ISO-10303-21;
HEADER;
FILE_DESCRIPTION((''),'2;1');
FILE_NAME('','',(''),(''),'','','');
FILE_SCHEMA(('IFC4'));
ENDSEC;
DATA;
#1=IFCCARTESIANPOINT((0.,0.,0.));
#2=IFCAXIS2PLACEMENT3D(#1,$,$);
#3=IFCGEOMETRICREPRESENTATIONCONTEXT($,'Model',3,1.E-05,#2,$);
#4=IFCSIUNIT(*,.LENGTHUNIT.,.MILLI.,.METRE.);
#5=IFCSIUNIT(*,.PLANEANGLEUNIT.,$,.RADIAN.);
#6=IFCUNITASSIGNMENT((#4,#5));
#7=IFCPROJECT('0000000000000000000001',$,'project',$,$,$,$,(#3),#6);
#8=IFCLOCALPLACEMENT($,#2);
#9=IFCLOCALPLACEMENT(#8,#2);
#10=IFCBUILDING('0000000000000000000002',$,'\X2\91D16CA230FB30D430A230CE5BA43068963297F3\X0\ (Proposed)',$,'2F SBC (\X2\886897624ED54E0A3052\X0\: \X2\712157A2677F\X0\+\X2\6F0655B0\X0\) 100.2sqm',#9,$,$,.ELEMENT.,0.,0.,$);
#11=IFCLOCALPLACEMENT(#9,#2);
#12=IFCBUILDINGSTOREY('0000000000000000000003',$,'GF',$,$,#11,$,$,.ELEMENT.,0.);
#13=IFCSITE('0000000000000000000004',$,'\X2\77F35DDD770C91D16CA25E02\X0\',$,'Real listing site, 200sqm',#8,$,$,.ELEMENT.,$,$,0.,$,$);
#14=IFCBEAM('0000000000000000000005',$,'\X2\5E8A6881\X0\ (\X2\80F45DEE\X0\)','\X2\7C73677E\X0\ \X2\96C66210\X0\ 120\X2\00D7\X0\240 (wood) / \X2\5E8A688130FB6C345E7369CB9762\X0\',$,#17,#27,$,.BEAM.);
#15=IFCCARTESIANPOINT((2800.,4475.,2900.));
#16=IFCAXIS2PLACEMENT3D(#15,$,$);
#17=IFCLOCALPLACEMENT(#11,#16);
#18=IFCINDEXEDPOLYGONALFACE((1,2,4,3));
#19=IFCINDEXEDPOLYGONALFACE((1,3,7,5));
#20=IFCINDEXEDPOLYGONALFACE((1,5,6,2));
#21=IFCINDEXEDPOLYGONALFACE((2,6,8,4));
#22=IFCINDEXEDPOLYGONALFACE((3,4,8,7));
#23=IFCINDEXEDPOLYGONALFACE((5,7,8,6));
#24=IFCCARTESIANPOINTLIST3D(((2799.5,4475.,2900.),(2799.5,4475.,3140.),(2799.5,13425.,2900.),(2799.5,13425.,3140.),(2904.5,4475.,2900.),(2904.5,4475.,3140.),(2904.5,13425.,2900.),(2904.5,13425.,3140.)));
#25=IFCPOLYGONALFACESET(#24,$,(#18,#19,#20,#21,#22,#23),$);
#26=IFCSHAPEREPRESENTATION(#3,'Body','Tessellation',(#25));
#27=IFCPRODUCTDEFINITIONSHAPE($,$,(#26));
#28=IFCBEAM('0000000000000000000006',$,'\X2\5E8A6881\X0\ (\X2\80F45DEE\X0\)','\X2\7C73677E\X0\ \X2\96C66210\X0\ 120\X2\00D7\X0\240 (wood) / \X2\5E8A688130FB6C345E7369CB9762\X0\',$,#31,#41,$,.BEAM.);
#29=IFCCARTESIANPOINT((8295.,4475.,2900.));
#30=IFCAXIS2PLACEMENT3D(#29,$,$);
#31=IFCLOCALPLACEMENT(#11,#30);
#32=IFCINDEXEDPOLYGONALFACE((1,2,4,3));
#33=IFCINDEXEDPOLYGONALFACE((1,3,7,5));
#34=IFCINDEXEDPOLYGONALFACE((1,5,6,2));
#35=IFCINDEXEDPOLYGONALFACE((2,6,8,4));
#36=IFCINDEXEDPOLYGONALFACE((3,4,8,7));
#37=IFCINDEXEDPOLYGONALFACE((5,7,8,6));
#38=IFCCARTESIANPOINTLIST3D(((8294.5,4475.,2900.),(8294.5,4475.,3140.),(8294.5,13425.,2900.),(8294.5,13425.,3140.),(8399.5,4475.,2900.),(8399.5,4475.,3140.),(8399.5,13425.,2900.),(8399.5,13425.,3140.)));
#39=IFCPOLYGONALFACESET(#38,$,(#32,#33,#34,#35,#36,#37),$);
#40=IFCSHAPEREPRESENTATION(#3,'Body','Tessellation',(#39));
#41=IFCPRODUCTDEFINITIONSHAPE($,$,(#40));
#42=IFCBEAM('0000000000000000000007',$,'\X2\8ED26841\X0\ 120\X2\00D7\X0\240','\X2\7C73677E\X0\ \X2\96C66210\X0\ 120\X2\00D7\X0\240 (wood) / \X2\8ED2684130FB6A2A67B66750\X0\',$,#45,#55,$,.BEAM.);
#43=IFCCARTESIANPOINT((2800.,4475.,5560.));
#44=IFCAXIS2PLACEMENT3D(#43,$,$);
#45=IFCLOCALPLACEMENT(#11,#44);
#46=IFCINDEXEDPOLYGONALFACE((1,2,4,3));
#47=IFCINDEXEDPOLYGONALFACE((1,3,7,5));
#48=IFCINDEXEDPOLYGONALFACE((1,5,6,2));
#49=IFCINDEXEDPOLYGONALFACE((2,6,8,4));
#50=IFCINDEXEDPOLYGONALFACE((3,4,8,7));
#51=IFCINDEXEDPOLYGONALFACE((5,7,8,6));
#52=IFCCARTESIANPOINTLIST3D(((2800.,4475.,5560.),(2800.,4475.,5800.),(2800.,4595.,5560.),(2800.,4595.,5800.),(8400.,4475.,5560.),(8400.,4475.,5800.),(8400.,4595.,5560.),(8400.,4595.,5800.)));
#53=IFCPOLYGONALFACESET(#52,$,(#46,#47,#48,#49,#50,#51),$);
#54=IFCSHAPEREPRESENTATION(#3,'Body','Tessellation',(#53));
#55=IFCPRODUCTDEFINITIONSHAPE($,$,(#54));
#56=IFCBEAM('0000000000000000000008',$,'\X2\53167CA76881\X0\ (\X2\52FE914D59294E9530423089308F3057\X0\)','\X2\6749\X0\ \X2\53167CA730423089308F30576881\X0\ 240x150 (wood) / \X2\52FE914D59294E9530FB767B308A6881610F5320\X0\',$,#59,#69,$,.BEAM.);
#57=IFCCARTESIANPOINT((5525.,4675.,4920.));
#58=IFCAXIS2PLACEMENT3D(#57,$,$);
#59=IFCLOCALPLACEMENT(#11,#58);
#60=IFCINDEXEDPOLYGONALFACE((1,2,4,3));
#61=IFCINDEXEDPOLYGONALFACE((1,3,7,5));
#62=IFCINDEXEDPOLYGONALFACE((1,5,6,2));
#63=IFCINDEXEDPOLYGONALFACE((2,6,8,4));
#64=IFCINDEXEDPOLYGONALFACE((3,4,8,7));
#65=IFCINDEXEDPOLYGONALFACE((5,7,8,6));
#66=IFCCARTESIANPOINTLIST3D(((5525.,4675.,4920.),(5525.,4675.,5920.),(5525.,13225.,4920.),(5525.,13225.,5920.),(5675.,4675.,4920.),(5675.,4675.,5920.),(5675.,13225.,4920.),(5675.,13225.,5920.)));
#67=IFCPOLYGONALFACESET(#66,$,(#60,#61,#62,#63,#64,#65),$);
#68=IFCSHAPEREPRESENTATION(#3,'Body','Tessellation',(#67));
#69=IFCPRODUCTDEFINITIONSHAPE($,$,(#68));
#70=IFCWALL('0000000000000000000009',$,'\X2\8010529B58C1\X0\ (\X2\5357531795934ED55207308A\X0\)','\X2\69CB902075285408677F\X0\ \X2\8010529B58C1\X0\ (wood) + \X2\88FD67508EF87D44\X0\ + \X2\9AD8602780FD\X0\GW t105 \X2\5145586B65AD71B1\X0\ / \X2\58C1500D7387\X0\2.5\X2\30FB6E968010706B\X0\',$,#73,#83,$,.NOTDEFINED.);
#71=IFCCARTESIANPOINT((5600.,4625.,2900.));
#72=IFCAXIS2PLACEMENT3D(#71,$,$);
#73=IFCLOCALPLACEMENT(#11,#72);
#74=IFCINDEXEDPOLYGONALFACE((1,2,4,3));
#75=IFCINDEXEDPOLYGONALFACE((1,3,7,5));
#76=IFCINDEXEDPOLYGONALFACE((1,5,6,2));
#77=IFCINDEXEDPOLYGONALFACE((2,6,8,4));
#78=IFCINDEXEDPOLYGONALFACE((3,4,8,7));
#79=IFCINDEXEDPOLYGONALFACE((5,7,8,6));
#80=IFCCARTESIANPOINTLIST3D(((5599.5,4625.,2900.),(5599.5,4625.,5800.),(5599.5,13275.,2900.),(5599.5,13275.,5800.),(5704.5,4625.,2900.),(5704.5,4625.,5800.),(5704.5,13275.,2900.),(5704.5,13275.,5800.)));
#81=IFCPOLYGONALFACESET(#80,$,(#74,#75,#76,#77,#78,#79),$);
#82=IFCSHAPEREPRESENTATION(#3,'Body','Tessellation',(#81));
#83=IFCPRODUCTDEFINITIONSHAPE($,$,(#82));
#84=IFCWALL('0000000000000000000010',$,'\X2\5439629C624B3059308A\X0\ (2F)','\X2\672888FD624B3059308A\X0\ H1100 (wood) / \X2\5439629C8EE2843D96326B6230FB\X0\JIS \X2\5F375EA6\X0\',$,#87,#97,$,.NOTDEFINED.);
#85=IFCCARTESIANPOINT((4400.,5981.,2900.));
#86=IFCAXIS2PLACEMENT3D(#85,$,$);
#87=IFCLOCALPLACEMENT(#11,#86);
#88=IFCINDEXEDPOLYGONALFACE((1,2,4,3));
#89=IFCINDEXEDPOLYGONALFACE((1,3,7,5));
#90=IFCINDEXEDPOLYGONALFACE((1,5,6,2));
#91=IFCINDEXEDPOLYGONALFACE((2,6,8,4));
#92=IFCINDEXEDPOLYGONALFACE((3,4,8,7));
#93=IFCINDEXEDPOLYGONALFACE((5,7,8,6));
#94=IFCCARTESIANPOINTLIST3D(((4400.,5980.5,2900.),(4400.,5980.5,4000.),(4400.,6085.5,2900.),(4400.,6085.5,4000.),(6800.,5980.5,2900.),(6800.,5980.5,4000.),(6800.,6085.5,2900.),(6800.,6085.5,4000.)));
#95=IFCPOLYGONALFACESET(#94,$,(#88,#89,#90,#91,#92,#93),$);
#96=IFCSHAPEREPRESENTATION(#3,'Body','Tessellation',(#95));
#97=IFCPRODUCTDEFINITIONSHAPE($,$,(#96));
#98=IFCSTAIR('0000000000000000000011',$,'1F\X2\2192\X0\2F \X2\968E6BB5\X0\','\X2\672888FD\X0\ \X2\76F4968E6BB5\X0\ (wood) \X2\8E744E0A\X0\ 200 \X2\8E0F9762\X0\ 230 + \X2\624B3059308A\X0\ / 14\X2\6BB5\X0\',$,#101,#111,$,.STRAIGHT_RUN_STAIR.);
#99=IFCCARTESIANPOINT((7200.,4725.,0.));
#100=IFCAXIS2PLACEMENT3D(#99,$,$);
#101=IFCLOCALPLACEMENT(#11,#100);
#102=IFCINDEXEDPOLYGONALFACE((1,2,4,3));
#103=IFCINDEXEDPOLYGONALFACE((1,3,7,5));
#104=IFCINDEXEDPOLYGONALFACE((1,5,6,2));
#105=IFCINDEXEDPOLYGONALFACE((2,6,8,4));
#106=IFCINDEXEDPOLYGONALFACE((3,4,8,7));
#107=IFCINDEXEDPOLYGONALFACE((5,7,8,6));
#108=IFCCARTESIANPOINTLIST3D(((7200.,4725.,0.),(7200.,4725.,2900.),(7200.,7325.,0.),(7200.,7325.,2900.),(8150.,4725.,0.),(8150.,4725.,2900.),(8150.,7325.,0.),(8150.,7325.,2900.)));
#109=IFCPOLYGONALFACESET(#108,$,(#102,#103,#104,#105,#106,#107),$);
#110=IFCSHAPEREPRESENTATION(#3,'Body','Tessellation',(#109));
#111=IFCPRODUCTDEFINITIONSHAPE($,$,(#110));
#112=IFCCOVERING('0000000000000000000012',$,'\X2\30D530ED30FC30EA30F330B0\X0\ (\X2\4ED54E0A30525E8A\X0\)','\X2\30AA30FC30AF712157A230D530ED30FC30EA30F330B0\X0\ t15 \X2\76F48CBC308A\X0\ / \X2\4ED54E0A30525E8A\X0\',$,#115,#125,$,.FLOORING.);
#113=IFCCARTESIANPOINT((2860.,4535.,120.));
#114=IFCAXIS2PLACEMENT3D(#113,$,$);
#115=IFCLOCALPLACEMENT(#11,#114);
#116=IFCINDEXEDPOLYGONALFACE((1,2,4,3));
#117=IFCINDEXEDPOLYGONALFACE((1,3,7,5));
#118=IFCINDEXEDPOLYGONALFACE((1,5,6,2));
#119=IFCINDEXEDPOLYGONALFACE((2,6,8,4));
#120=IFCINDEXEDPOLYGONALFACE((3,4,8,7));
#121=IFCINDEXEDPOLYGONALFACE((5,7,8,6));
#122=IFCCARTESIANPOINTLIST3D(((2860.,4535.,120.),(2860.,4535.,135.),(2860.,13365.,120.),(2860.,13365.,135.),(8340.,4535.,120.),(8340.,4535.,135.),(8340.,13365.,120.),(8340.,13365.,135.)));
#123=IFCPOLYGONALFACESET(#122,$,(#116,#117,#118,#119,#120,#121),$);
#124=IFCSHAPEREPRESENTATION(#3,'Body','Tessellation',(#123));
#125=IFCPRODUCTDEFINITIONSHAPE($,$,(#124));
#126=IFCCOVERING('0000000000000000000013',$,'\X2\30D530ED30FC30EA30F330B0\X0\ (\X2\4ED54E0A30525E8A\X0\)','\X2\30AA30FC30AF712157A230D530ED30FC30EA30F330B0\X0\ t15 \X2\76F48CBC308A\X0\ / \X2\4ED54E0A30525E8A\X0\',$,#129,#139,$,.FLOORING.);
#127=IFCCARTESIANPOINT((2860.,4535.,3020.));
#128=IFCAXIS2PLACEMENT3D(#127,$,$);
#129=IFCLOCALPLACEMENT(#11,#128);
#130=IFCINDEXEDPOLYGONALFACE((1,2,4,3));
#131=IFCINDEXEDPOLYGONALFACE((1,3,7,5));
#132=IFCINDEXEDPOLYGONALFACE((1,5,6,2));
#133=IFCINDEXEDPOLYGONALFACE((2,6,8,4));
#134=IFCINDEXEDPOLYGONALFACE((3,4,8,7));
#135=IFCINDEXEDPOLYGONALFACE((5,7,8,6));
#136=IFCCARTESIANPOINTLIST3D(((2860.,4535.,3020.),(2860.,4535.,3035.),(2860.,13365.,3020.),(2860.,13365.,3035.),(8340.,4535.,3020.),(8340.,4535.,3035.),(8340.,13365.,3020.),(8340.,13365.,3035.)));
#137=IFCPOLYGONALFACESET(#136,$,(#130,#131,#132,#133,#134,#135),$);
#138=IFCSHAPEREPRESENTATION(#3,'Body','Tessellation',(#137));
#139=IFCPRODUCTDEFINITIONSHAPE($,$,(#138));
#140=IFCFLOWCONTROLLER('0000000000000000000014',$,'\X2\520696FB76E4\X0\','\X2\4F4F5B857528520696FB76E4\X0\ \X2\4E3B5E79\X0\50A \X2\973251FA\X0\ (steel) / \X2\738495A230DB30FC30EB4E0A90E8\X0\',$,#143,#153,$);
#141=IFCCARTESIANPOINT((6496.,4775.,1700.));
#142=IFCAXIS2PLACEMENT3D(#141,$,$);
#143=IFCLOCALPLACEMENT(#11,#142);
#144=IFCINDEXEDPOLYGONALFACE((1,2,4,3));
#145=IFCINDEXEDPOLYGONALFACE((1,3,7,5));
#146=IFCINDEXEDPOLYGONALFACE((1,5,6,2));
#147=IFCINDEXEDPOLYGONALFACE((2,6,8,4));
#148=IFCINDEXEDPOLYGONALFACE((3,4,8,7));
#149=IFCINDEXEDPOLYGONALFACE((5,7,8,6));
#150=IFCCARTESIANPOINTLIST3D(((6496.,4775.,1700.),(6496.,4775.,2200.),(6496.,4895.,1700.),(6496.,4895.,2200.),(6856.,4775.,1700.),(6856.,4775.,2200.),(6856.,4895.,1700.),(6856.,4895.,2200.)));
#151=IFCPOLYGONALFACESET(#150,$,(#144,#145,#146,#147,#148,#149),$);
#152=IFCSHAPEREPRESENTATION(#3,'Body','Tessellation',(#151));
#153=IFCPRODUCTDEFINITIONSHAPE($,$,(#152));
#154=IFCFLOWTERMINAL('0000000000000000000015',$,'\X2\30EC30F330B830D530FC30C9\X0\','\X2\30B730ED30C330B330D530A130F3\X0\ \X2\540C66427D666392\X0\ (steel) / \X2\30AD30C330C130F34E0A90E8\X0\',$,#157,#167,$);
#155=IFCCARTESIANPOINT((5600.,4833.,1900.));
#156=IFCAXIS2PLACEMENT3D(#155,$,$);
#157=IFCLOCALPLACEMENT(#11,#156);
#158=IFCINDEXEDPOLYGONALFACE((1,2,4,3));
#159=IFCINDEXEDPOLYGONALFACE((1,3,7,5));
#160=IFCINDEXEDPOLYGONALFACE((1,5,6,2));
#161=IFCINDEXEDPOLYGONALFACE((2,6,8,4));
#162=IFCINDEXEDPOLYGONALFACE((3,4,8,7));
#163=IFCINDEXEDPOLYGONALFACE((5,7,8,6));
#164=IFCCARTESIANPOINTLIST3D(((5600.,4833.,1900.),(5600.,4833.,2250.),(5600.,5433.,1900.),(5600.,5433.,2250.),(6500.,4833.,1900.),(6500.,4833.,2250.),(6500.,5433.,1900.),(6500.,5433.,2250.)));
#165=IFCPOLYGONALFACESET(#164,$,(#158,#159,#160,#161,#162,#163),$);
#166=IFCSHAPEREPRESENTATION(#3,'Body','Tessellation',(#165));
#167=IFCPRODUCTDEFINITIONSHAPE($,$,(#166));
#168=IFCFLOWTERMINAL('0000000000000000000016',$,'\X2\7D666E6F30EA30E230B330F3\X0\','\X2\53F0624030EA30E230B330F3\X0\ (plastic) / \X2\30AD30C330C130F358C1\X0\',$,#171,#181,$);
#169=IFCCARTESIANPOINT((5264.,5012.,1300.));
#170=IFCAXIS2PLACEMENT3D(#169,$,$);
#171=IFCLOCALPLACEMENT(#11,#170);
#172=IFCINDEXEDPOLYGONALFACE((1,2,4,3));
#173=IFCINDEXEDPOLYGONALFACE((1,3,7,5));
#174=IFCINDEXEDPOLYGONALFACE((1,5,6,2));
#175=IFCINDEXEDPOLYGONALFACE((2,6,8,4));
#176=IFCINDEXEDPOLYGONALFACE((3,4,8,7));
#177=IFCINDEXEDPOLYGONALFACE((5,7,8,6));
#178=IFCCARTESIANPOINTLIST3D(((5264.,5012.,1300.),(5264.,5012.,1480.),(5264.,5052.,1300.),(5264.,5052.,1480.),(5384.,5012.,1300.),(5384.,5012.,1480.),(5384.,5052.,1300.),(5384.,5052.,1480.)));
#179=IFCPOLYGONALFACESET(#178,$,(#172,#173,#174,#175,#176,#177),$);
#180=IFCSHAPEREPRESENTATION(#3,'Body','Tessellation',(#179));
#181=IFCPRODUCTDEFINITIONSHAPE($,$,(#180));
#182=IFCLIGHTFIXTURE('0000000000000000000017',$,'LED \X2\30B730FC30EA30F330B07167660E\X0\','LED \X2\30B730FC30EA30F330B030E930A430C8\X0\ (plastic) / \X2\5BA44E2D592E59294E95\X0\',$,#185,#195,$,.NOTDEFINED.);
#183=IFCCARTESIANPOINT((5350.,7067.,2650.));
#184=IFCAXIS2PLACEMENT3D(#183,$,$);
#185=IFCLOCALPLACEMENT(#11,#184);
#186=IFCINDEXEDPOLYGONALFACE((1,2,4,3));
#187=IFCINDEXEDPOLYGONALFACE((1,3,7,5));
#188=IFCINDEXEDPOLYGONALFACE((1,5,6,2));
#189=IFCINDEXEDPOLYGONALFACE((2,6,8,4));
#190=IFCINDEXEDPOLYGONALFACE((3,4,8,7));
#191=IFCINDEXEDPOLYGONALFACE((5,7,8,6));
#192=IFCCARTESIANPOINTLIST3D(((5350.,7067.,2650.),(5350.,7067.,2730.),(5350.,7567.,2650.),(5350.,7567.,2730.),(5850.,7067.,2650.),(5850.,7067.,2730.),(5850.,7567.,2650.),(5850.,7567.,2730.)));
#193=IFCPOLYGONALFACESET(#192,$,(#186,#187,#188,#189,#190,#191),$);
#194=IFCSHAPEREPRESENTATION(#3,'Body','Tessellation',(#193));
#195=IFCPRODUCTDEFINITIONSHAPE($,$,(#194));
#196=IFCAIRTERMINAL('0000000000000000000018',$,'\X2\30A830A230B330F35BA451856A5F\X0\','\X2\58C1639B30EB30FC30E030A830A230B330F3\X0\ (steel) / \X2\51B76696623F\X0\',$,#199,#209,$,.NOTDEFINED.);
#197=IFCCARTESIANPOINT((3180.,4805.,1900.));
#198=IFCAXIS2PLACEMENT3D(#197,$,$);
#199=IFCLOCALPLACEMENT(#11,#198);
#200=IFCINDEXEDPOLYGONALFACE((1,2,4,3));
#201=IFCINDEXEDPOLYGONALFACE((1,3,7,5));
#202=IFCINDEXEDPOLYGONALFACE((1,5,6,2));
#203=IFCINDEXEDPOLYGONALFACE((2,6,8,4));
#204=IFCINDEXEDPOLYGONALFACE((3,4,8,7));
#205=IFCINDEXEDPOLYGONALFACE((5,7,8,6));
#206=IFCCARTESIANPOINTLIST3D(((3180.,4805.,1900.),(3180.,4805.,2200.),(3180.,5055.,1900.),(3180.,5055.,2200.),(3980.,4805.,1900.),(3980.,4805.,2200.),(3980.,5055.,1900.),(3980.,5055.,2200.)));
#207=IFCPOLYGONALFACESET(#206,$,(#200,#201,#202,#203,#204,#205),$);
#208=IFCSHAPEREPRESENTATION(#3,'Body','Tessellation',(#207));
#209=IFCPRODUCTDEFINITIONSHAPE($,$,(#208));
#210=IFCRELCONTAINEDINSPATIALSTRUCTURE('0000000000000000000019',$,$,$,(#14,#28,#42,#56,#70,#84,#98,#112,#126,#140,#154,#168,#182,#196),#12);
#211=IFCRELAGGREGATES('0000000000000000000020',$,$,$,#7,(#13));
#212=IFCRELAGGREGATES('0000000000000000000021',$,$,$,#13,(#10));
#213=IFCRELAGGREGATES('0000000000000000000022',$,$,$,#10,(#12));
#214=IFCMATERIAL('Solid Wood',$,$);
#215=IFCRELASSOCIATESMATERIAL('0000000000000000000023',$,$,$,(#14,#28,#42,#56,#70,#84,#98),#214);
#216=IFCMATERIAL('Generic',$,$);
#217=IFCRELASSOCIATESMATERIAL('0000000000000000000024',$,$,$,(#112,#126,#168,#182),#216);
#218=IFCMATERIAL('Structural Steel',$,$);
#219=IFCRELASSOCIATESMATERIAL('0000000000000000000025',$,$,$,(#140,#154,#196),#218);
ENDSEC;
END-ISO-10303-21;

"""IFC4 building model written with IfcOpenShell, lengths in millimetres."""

from ifc_helpers import new_model, si_unit, frame, frame_2d, origin, place, context, project, spatial, rectangle, extrude, material, element, save


model = new_model("IFC4")

# Units and contexts
model_context = context("Model", 3, precision=1e-05, world=origin())
ifc_project = project(units=[si_unit("LENGTHUNIT", "METRE", prefix="MILLI"), si_unit("PLANEANGLEUNIT", "RADIAN")], contexts=[model_context])

# Site, building, storey
site_placement = place(None, origin())
site = spatial("IfcSite", under=ifc_project, at=site_placement, Name="石川県金沢市", ObjectType="Real listing site, 200sqm", CompositionType="ELEMENT", RefElevation=0.0)
building_placement = place(site_placement, origin())
building = spatial("IfcBuilding", under=site, at=building_placement, Name="金沢・ピアノ室と防音 (Proposed)", ObjectType="2F SBC (表面仕上げ: 無垢板+漆喰) 100.2sqm", CompositionType="ELEMENT", ElevationOfRefHeight=0.0, ElevationOfTerrain=0.0)
storey_placement = place(building_placement, origin())
storey = spatial("IfcBuildingStorey", under=building, at=storey_placement, Name="GF", CompositionType="ELEMENT", Elevation=0.0)

# Shared definitions
ifc_material_1 = material(Name="Solid Wood")

# Beams
beam_1_placement = place(storey_placement, frame((2800.0, 4475.0, 2900.0)))
element("IfcBeam", 1, at=beam_1_placement, inside=storey, material=ifc_material_1, Name="床梁 (胴差)", Description="米松 集成 120×240 (wood) / 床梁・水平構面", PredefinedType="BEAM", context=model_context, shape_type="SweptSolid", body=[
    extrude(rectangle(XDim=105.0, YDim=8950.0, at=frame_2d((52.0, 4475.0))), frame((2800.0, 4475.0, 2900.0)), (0.0, 0.0, 1.0), 240.0),
])
beam_2_placement = place(storey_placement, frame((8295.0, 4475.0, 2900.0)))
element("IfcBeam", 2, at=beam_2_placement, inside=storey, material=ifc_material_1, Name="床梁 (胴差)", Description="米松 集成 120×240 (wood) / 床梁・水平構面", PredefinedType="BEAM", context=model_context, shape_type="SweptSolid", body=[
    extrude(rectangle(XDim=105.0, YDim=8950.0, at=frame_2d((52.0, 4475.0))), frame((8295.0, 4475.0, 2900.0)), (0.0, 0.0, 1.0), 240.0),
])
beam_3_placement = place(storey_placement, frame((2800.0, 4475.0, 5560.0)))
element("IfcBeam", 3, at=beam_3_placement, inside=storey, material=ifc_material_1, Name="軒桁 120×240", Description="米松 集成 120×240 (wood) / 軒桁・横架材", PredefinedType="BEAM", context=model_context, shape_type="SweptSolid", body=[
    extrude(rectangle(XDim=5600.0, YDim=120.0, at=frame_2d((2800.0, 60.0))), frame((2800.0, 4475.0, 5560.0)), (0.0, 0.0, 1.0), 240.0),
])
beam_4_placement = place(storey_placement, frame((5525.0, 4675.0, 4920.0)))
element("IfcBeam", 4, at=beam_4_placement, inside=storey, material=ifc_material_1, Name="化粧梁 (勾配天井あらわし)", Description="杉 化粧あらわし梁 240x150 (wood) / 勾配天井・登り梁意匠", PredefinedType="BEAM", context=model_context, shape_type="SweptSolid", body=[
    extrude(rectangle(XDim=150.0, YDim=8550.0, at=frame_2d((75.0, 4275.0))), frame((5525.0, 4675.0, 4920.0)), (0.0, 0.0, 1.0), 1000.0),
])

# Walls
wall_1_placement = place(storey_placement, frame((5600.0, 4625.0, 2900.0)))
element("IfcWall", 5, at=wall_1_placement, inside=storey, material=ifc_material_1, Name="耐力壁 (南北間仕切り)", Description="構造用合板 耐力壁 (wood) + 製材軸組 + 高性能GW t105 充填断熱 / 壁倍率2.5・準耐火", PredefinedType="NOTDEFINED", context=model_context, shape_type="SweptSolid", body=[
    extrude(rectangle(XDim=105.0, YDim=8650.0, at=frame_2d((52.0, 4325.0))), frame((5600.0, 4625.0, 2900.0)), (0.0, 0.0, 1.0), 2900.0),
])
wall_2_placement = place(storey_placement, frame((4400.0, 5981.0, 2900.0)))
element("IfcWall", 6, at=wall_2_placement, inside=storey, material=ifc_material_1, Name="吹抜手すり (2F)", Description="木製手すり H1100 (wood) / 吹抜転落防止・JIS 強度", PredefinedType="NOTDEFINED", context=model_context, shape_type="SweptSolid", body=[
    extrude(rectangle(XDim=2400.0, YDim=105.0, at=frame_2d((1200.0, 52.0))), frame((4400.0, 5981.0, 2900.0)), (0.0, 0.0, 1.0), 1100.0),
])

# Stair
stair_placement = place(storey_placement, frame((7200.0, 4725.0, 0.0)))
element("IfcStair", 7, at=stair_placement, inside=storey, material=ifc_material_1, Name="1F→2F 階段", Description="木製 直階段 (wood) 蹴上 200 踏面 230 + 手すり / 14段", PredefinedType="STRAIGHT_RUN_STAIR", context=model_context, shape_type="SweptSolid", body=[
    extrude(rectangle(XDim=950.0, YDim=2600.0, at=frame_2d((475.0, 1300.0))), frame((7200.0, 4725.0, 0.0)), (0.0, 0.0, 1.0), 2900.0),
])

# Coverings
ifc_material_2 = material(Name="Generic")
covering_1_placement = place(storey_placement, frame((2860.0, 4535.0, 120.0)))
element("IfcCovering", 8, at=covering_1_placement, inside=storey, material=ifc_material_2, Name="フローリング (仕上げ床)", Description="オーク無垢フローリング t15 直貼り / 仕上げ床", PredefinedType="FLOORING", context=model_context, shape_type="SweptSolid", body=[
    extrude(rectangle(XDim=5480.0, YDim=8830.0, at=frame_2d((2740.0, 4415.0))), frame((2860.0, 4535.0, 120.0)), (0.0, 0.0, 1.0), 15.0),
])
covering_2_placement = place(storey_placement, frame((2860.0, 4535.0, 3020.0)))
element("IfcCovering", 9, at=covering_2_placement, inside=storey, material=ifc_material_2, Name="フローリング (仕上げ床)", Description="オーク無垢フローリング t15 直貼り / 仕上げ床", PredefinedType="FLOORING", context=model_context, shape_type="SweptSolid", body=[
    extrude(rectangle(XDim=5480.0, YDim=8830.0, at=frame_2d((2740.0, 4415.0))), frame((2860.0, 4535.0, 3020.0)), (0.0, 0.0, 1.0), 15.0),
])

# Flow controller
ifc_material_3 = material(Name="Structural Steel")
flow_controller_placement = place(storey_placement, frame((6496.0, 4775.0, 1700.0)))
element("IfcFlowController", 10, at=flow_controller_placement, inside=storey, material=ifc_material_3, Name="分電盤", Description="住宅用分電盤 主幹50A 露出 (steel) / 玄関ホール上部", context=model_context, shape_type="SweptSolid", body=[
    extrude(rectangle(XDim=360.0, YDim=120.0, at=frame_2d((180.0, 60.0))), frame((6496.0, 4775.0, 1700.0)), (0.0, 0.0, 1.0), 500.0),
])

# Flow terminals
flow_terminal_1_placement = place(storey_placement, frame((5600.0, 4833.0, 1900.0)))
element("IfcFlowTerminal", 11, at=flow_terminal_1_placement, inside=storey, material=ifc_material_3, Name="レンジフード", Description="シロッコファン 同時給排 (steel) / キッチン上部", context=model_context, shape_type="SweptSolid", body=[
    extrude(rectangle(XDim=900.0, YDim=600.0, at=frame_2d((450.0, 300.0))), frame((5600.0, 4833.0, 1900.0)), (0.0, 0.0, 1.0), 350.0),
])
flow_terminal_2_placement = place(storey_placement, frame((5264.0, 5012.0, 1300.0)))
element("IfcFlowTerminal", 12, at=flow_terminal_2_placement, inside=storey, material=ifc_material_2, Name="給湯リモコン", Description="台所リモコン (plastic) / キッチン壁", context=model_context, shape_type="SweptSolid", body=[
    extrude(rectangle(XDim=120.0, YDim=40.0, at=frame_2d((60.0, 20.0))), frame((5264.0, 5012.0, 1300.0)), (0.0, 0.0, 1.0), 180.0),
])

# Light fixture
light_fixture_1_placement = place(storey_placement, frame((5350.0, 7067.0, 2650.0)))
element("IfcLightFixture", 13, at=light_fixture_1_placement, inside=storey, material=ifc_material_2, Name="LED シーリング照明", Description="LED シーリングライト (plastic) / 室中央天井", PredefinedType="NOTDEFINED", context=model_context, shape_type="SweptSolid", body=[
    extrude(rectangle(XDim=500.0, YDim=500.0, at=frame_2d((250.0, 250.0))), frame((5350.0, 7067.0, 2650.0)), (0.0, 0.0, 1.0), 80.0),
])

# Air terminal
air_terminal_1_placement = place(storey_placement, frame((3180.0, 4805.0, 1900.0)))
element("IfcAirTerminal", 14, at=air_terminal_1_placement, inside=storey, material=ifc_material_3, Name="エアコン室内機", Description="壁掛ルームエアコン (steel) / 冷暖房", PredefinedType="NOTDEFINED", context=model_context, shape_type="SweptSolid", body=[
    extrude(rectangle(XDim=800.0, YDim=250.0, at=frame_2d((400.0, 125.0))), frame((3180.0, 4805.0, 1900.0)), (0.0, 0.0, 1.0), 300.0),
])

save(model, "model.ifc")
